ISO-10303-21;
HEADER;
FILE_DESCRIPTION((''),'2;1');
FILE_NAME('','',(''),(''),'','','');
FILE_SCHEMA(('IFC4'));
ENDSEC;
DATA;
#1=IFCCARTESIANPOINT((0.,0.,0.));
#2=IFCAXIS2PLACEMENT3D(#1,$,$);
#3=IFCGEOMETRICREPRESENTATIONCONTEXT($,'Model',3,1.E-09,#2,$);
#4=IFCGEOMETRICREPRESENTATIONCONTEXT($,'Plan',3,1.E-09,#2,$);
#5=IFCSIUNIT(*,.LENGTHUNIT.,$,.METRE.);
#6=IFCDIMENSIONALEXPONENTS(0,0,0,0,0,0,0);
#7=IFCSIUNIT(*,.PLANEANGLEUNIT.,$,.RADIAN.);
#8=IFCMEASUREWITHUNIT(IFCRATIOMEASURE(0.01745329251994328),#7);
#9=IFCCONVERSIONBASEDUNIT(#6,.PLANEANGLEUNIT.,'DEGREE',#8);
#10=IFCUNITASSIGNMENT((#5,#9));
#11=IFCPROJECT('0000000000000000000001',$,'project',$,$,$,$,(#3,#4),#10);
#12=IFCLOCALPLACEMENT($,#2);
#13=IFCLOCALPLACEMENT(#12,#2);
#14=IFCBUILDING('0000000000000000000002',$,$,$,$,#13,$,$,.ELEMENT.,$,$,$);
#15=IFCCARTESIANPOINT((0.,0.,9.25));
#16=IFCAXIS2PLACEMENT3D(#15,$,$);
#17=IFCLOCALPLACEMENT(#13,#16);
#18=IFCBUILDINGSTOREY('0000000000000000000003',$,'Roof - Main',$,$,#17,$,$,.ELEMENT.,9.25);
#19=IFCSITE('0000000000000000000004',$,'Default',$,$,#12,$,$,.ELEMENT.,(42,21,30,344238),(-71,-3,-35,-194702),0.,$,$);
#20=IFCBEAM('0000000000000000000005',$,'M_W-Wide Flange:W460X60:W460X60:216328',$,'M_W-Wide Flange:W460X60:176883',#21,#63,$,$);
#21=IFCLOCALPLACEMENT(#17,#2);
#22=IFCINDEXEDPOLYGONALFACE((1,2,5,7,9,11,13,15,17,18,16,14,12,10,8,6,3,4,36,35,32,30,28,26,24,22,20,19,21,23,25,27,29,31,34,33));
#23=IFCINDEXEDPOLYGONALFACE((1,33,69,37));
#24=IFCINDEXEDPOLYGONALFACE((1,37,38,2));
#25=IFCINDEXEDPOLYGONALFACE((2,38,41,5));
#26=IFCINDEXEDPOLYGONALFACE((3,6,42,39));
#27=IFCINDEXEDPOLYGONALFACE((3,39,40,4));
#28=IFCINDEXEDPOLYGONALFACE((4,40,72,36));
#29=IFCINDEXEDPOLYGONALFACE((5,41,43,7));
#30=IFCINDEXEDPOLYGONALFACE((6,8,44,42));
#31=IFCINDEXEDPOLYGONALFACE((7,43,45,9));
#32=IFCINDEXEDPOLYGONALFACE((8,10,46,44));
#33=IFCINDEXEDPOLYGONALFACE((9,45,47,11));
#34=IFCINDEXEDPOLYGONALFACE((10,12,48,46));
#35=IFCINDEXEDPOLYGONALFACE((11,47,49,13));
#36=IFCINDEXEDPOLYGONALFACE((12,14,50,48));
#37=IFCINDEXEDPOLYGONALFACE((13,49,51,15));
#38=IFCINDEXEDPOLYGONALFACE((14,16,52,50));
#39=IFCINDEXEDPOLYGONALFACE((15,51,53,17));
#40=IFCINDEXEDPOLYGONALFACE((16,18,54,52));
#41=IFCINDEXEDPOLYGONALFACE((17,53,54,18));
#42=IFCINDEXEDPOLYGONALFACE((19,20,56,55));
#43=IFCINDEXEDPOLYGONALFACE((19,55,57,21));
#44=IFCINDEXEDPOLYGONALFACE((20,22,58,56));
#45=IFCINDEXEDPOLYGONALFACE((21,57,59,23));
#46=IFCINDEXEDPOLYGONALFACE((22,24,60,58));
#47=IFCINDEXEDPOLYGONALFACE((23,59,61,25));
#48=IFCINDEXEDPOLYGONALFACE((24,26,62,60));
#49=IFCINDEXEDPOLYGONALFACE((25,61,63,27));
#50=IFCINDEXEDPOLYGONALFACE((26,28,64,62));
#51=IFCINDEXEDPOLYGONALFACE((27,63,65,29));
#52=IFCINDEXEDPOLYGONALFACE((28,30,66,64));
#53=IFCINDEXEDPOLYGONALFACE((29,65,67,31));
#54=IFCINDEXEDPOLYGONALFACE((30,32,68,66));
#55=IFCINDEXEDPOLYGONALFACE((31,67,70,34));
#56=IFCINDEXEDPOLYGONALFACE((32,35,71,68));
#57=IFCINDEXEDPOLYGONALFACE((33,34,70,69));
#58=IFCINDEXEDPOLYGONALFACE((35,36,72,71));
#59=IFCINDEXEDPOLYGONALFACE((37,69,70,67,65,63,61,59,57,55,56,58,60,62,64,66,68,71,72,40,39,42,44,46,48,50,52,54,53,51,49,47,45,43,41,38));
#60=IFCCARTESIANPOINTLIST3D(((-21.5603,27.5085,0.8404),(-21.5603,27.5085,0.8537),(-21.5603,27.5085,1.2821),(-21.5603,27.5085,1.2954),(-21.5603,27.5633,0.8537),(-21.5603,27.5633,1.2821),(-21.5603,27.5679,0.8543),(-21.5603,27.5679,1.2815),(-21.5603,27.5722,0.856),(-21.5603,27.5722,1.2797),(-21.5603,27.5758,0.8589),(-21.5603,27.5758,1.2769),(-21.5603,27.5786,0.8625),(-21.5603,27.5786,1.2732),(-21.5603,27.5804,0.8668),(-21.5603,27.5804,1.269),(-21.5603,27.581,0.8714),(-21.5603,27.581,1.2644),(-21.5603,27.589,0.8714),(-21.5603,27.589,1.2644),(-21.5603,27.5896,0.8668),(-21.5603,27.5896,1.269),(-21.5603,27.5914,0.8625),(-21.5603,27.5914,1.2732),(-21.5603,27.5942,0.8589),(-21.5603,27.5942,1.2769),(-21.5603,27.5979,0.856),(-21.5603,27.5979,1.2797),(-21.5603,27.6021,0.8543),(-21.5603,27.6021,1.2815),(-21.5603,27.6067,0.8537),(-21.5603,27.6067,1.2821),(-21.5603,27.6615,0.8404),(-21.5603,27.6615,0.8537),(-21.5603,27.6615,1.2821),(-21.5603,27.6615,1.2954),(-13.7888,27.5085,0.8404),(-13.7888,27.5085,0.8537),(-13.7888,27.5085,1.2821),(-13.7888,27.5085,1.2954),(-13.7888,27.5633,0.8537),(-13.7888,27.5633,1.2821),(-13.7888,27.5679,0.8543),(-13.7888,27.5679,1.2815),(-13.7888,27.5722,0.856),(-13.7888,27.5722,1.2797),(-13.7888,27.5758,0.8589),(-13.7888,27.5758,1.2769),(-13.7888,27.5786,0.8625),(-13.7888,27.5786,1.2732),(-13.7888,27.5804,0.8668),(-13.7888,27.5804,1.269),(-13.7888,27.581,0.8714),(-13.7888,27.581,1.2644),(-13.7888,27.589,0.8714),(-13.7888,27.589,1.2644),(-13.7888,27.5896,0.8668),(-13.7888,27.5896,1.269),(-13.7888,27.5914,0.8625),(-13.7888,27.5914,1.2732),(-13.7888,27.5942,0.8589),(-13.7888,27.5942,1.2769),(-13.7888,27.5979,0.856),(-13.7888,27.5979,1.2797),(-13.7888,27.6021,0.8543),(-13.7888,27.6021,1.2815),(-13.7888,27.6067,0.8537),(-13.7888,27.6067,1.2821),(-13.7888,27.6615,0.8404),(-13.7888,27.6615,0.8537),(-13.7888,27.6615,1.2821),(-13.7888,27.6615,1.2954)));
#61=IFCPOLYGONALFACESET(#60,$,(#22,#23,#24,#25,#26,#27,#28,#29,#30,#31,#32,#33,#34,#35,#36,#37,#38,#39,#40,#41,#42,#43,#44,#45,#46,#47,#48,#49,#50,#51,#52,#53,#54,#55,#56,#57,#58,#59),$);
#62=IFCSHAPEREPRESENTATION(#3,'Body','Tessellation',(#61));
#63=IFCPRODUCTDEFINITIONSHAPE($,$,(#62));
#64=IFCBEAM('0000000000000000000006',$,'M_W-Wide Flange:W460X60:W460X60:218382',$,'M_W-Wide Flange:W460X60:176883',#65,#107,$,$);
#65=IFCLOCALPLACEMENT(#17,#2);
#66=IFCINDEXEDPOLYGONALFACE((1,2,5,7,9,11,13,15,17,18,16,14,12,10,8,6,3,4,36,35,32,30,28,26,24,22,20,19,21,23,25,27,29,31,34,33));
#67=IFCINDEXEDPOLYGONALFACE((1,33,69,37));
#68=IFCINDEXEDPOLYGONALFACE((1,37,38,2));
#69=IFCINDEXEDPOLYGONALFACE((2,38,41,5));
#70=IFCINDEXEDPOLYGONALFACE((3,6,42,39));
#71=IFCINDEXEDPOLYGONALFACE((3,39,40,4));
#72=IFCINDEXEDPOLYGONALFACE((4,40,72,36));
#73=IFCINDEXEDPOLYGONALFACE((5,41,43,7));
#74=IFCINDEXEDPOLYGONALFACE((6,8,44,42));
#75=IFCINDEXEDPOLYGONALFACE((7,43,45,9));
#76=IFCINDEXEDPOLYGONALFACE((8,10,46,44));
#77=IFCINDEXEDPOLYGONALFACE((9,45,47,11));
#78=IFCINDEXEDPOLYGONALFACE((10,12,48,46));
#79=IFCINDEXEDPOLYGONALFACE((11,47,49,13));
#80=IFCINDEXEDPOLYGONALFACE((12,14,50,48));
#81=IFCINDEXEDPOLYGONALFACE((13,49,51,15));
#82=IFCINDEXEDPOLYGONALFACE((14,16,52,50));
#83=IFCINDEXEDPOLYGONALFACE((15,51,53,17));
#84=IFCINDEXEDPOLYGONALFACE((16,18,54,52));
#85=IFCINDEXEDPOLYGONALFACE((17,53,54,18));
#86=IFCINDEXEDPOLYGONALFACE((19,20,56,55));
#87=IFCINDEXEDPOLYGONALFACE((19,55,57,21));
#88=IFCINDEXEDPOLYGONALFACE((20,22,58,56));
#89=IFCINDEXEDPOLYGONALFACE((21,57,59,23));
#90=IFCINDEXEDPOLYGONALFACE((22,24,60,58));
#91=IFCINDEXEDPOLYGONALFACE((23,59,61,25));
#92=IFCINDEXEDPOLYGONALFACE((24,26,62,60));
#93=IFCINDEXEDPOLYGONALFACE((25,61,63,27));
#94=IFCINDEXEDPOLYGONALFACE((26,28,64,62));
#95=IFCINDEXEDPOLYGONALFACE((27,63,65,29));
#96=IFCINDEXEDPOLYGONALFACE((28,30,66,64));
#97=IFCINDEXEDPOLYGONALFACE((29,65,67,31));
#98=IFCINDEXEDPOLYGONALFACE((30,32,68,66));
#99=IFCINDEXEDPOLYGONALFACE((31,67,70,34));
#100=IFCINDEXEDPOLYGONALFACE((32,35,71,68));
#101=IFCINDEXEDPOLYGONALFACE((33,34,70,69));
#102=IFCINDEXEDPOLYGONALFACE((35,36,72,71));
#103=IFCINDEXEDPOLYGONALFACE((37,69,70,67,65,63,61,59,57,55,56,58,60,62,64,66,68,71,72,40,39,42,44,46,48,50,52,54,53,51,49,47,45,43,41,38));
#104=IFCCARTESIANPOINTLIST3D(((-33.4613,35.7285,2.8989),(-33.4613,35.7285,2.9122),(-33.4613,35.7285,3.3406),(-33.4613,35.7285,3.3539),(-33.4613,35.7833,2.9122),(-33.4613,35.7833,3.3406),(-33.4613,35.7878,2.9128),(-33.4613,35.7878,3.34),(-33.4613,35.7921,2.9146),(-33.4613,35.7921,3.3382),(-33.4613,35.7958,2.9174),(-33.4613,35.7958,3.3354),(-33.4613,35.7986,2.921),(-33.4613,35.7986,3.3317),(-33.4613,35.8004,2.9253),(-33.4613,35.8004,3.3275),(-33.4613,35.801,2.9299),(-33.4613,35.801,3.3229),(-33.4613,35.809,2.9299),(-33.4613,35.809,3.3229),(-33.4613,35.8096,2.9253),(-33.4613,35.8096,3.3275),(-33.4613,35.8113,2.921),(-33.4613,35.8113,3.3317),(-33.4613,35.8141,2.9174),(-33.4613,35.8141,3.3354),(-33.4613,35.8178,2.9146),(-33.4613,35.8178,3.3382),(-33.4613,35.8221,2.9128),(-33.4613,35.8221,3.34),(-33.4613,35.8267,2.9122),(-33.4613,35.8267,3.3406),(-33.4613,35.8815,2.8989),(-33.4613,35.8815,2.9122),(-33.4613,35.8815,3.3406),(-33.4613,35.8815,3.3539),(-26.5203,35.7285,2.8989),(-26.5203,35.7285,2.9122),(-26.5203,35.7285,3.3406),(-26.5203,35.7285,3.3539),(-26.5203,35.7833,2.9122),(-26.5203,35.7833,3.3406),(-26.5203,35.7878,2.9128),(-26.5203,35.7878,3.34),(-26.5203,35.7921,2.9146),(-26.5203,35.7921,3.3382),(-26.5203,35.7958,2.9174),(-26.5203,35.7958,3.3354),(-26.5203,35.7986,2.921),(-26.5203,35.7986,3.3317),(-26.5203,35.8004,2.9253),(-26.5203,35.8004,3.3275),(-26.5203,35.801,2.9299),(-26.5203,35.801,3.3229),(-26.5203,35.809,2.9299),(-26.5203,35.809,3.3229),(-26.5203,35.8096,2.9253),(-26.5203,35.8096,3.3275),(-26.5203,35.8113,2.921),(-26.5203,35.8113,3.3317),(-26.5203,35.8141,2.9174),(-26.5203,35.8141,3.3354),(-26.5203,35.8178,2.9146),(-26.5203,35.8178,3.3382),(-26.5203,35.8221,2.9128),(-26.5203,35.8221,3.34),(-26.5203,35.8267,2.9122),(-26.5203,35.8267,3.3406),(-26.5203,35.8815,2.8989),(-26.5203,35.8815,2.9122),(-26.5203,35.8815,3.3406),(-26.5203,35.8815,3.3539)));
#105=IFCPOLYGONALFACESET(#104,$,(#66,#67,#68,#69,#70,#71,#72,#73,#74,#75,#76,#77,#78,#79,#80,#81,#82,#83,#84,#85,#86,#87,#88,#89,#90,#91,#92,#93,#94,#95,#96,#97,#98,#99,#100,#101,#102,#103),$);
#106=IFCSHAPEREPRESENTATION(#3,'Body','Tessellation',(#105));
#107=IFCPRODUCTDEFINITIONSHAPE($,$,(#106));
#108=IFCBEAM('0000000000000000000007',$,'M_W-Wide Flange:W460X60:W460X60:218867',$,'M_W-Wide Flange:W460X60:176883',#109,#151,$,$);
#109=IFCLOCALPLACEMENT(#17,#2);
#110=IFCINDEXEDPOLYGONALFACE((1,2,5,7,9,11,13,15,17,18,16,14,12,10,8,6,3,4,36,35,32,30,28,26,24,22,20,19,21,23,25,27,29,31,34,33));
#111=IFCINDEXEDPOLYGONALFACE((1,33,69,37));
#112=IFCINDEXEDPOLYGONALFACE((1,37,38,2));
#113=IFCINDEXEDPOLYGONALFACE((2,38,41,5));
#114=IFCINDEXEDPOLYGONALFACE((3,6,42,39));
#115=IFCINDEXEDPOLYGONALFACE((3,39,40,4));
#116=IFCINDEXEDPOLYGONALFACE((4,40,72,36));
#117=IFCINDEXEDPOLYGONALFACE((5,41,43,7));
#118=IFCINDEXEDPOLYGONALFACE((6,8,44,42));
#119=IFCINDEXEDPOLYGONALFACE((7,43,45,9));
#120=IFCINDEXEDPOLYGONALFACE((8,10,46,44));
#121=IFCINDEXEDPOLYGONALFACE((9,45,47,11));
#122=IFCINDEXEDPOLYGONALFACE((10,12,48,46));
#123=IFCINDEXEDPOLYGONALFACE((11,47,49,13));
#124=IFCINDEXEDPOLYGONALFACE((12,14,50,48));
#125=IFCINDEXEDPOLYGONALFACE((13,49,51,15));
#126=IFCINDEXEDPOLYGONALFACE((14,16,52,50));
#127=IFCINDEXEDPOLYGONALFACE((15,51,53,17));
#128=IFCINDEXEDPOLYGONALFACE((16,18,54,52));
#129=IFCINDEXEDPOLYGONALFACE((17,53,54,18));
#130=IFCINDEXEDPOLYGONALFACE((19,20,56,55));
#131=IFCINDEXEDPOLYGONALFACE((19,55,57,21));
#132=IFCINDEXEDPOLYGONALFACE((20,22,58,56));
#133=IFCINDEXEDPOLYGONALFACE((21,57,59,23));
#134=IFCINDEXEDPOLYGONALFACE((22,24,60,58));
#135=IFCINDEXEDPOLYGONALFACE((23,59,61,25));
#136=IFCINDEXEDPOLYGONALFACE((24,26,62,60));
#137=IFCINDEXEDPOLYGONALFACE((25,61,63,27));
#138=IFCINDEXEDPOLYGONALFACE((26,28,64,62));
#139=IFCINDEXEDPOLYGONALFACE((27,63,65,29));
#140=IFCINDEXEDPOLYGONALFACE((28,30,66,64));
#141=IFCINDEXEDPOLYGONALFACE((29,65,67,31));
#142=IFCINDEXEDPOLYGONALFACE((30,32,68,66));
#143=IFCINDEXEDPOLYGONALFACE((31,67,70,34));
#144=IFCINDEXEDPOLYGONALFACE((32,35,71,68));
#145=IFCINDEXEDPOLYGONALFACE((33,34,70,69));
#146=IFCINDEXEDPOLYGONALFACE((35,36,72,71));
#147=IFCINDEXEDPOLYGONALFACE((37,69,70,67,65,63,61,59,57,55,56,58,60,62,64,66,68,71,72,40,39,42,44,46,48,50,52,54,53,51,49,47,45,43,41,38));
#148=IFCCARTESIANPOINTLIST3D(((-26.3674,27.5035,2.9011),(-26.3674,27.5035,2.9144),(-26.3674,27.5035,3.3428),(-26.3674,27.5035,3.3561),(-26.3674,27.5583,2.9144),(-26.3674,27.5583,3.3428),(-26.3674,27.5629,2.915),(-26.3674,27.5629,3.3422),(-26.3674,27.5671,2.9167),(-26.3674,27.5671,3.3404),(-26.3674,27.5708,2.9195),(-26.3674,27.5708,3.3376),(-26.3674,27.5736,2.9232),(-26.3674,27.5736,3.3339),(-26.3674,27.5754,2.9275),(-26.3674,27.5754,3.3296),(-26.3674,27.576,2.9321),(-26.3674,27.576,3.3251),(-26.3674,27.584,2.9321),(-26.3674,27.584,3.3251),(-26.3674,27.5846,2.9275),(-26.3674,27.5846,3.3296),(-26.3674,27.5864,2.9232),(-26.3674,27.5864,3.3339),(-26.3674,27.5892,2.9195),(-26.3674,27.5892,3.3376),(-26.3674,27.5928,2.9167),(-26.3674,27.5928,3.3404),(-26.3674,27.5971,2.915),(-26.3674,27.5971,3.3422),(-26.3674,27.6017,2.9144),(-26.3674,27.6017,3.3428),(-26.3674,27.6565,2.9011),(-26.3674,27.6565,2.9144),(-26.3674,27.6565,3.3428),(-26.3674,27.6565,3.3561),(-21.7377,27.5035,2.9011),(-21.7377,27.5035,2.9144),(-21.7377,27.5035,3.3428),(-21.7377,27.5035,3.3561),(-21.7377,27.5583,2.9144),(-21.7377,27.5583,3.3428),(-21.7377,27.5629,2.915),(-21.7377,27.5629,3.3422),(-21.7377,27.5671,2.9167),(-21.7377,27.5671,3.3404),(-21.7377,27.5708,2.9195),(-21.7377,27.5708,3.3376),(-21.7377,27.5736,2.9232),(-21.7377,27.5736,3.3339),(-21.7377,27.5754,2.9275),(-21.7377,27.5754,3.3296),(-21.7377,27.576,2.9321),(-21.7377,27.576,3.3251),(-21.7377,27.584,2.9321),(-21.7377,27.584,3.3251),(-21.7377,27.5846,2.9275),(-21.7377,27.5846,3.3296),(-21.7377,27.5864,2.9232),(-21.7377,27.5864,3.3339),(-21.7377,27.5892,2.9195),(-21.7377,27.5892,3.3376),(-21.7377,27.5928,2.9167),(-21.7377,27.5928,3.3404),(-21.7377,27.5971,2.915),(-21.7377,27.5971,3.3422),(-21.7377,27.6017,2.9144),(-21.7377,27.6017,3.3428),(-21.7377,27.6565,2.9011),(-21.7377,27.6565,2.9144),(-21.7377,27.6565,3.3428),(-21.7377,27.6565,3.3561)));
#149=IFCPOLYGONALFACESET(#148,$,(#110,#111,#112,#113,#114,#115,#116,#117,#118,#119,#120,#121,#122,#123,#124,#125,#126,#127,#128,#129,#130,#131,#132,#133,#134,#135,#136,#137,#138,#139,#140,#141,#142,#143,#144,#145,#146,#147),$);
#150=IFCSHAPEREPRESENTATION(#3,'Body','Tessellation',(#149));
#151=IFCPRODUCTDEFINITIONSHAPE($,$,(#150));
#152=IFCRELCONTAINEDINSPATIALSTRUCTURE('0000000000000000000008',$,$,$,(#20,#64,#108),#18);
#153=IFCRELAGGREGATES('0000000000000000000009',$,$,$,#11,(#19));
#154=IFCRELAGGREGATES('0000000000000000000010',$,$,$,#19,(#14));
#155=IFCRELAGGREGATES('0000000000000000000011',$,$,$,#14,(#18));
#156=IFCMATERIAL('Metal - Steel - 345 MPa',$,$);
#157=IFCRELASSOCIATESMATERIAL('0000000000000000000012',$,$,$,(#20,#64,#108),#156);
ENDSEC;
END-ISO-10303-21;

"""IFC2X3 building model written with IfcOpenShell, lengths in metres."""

from ifc_helpers import new_model, entity, si_unit, converted_unit, frame, frame_2d, origin, place, context, project, spatial, polyline, circle_curve, parameter, trimmed, segment, composite_curve, outline, extrude, material, element, save


model = new_model("IFC2X3")

# Units and contexts
model_context = context("Model", 3, precision=1e-09, world=origin())
plan_context = context("Plan", 3, precision=1e-09, world=origin())
ifc_project = project(units=[si_unit("LENGTHUNIT", "METRE"), converted_unit("PLANEANGLEUNIT", "DEGREE", entity("IfcRatioMeasure", 0.01745329251994328), si_unit("PLANEANGLEUNIT", "RADIAN"), dimensions=[0, 0, 0, 0, 0, 0, 0])], contexts=[model_context, plan_context])

# Site, building, storey
site_placement = place(None, origin())
site = spatial("IfcSite", under=ifc_project, at=site_placement, Name="Default", CompositionType="ELEMENT", RefLatitude=(42, 21, 30, 344238), RefLongitude=(-71, -3, -35, -194702), RefElevation=0.0)
building_placement = place(site_placement, origin())
building = spatial("IfcBuilding", under=site, at=building_placement, CompositionType="ELEMENT")
storey_placement = place(building_placement, frame((0.0, 0.0, 9.25)))
storey = spatial("IfcBuildingStorey", under=building, at=storey_placement, Name="Roof - Main", CompositionType="ELEMENT", Elevation=9.25)

# Shared definitions
ifc_material_1 = material(Name="Metal - Steel - 345 MPa")

# Beams
beam_1_placement = place(storey_placement, frame((-7.2776, 27.585, 1.2954), z_axis=(0.0, 0.0, 1.0), x_axis=(0.0, -1.0, 0.0)))
element("IfcBeam", 1, at=beam_1_placement, inside=storey, material=ifc_material_1, Name="M_W-Wide Flange:W460X60:W460X60:216328", ObjectType="M_W-Wide Flange:W460X60:176883", context=model_context, shape_type="SweptSolid", body=[
    extrude(outline(composite_curve([segment(polyline([(0.2142, -0.0765), (0.2275, -0.0765)]), True, "CONTINUOUS"), segment(polyline([(0.2275, -0.0765), (0.2275, 0.0765)]), True, "CONTINUOUS"), segment(polyline([(0.2275, 0.0765), (0.2142, 0.0765)]), True, "CONTINUOUS"), segment(polyline([(0.2142, 0.0765), (0.2142, 0.0217)]), True, "CONTINUOUS"), segment(trimmed(circle_curve(frame_2d((0.1965, 0.0217), x_axis=(0.0, 1.0)), 0.0177), [parameter(180.0)], [parameter(270.0)], True, "PARAMETER"), False, "CONTINUOUS"), segment(polyline([(0.1965, 0.004), (-0.1965, 0.004)]), True, "CONTINUOUS"), segment(trimmed(circle_curve(frame_2d((-0.1965, 0.0217), x_axis=(0.0, 1.0)), 0.0177), [parameter(90.0)], [parameter(180.0)], True, "PARAMETER"), False, "CONTINUOUS"), segment(polyline([(-0.2142, 0.0217), (-0.2142, 0.0765)]), True, "CONTINUOUS"), segment(polyline([(-0.2142, 0.0765), (-0.2275, 0.0765)]), True, "CONTINUOUS"), segment(polyline([(-0.2275, 0.0765), (-0.2275, -0.0765)]), True, "CONTINUOUS"), segment(polyline([(-0.2275, -0.0765), (-0.2142, -0.0765)]), True, "CONTINUOUS"), segment(polyline([(-0.2142, -0.0765), (-0.2142, -0.0217)]), True, "CONTINUOUS"), segment(trimmed(circle_curve(frame_2d((-0.1965, -0.0217), x_axis=(0.0, 1.0)), 0.0177), [parameter(360.0)], [parameter(90.0)], True, "PARAMETER"), False, "CONTINUOUS"), segment(polyline([(-0.1965, -0.004), (0.1965, -0.004)]), True, "CONTINUOUS"), segment(trimmed(circle_curve(frame_2d((0.1965, -0.0217), x_axis=(0.0, 1.0)), 0.0177), [parameter(270.0)], [parameter(0.0)], True, "PARAMETER"), False, "CONTINUOUS"), segment(polyline([(0.2142, -0.0217), (0.2142, -0.0765)]), True, "CONTINUOUS")], self_intersect=False)), frame((0.0, -14.2827, -0.2275), z_axis=(0.0, 1.0, 0.0), x_axis=(0.0, 0.0, -1.0)), (0.0, 0.0, 1.0), 7.7715),
])
beam_2_placement = place(storey_placement, frame((-6.691, 35.805, 3.3539), z_axis=(0.0, 0.0, 1.0), x_axis=(0.0, -1.0, 0.0)))
element("IfcBeam", 2, at=beam_2_placement, inside=storey, material=ifc_material_1, Name="M_W-Wide Flange:W460X60:W460X60:218382", ObjectType="M_W-Wide Flange:W460X60:176883", context=model_context, shape_type="SweptSolid", body=[
    extrude(outline(composite_curve([segment(polyline([(-0.0765, -0.2142), (-0.0765, -0.2275)]), True, "CONTINUOUS"), segment(polyline([(-0.0765, -0.2275), (0.0765, -0.2275)]), True, "CONTINUOUS"), segment(polyline([(0.0765, -0.2275), (0.0765, -0.2142)]), True, "CONTINUOUS"), segment(polyline([(0.0765, -0.2142), (0.0217, -0.2142)]), True, "CONTINUOUS"), segment(trimmed(circle_curve(frame_2d((0.0217, -0.1965), x_axis=(1.0, 0.0)), 0.0177), [parameter(180.0)], [parameter(270.0)], True, "PARAMETER"), False, "CONTINUOUS"), segment(polyline([(0.004, -0.1965), (0.004, 0.1965)]), True, "CONTINUOUS"), segment(trimmed(circle_curve(frame_2d((0.0217, 0.1965), x_axis=(1.0, 0.0)), 0.0177), [parameter(90.0)], [parameter(180.0)], True, "PARAMETER"), False, "CONTINUOUS"), segment(polyline([(0.0217, 0.2142), (0.0765, 0.2142)]), True, "CONTINUOUS"), segment(polyline([(0.0765, 0.2142), (0.0765, 0.2275)]), True, "CONTINUOUS"), segment(polyline([(0.0765, 0.2275), (-0.0765, 0.2275)]), True, "CONTINUOUS"), segment(polyline([(-0.0765, 0.2275), (-0.0765, 0.2142)]), True, "CONTINUOUS"), segment(polyline([(-0.0765, 0.2142), (-0.0217, 0.2142)]), True, "CONTINUOUS"), segment(trimmed(circle_curve(frame_2d((-0.0217, 0.1965), x_axis=(1.0, 0.0)), 0.0177), [parameter(360.0)], [parameter(90.0)], True, "PARAMETER"), False, "CONTINUOUS"), segment(polyline([(-0.004, 0.1965), (-0.004, -0.1965)]), True, "CONTINUOUS"), segment(trimmed(circle_curve(frame_2d((-0.0217, -0.1965), x_axis=(1.0, 0.0)), 0.0177), [parameter(270.0)], [parameter(0.0)], True, "PARAMETER"), False, "CONTINUOUS"), segment(polyline([(-0.0217, -0.2142), (-0.0765, -0.2142)]), True, "CONTINUOUS")], self_intersect=False)), frame((0.0, -26.7703, -0.2275), z_axis=(0.0, -1.0, 0.0), x_axis=(1.0, 0.0, 0.0)), (0.0, 0.0, -1.0), 6.941),
])
beam_3_placement = place(storey_placement, frame((-6.691, 27.58, 3.3561), z_axis=(0.0, 0.0, 1.0), x_axis=(0.0, -1.0, 0.0)))
element("IfcBeam", 3, at=beam_3_placement, inside=storey, material=ifc_material_1, Name="M_W-Wide Flange:W460X60:W460X60:218867", ObjectType="M_W-Wide Flange:W460X60:176883", context=model_context, shape_type="SweptSolid", body=[
    extrude(outline(composite_curve([segment(polyline([(0.2142, -0.0765), (0.2275, -0.0765)]), True, "CONTINUOUS"), segment(polyline([(0.2275, -0.0765), (0.2275, 0.0765)]), True, "CONTINUOUS"), segment(polyline([(0.2275, 0.0765), (0.2142, 0.0765)]), True, "CONTINUOUS"), segment(polyline([(0.2142, 0.0765), (0.2142, 0.0217)]), True, "CONTINUOUS"), segment(trimmed(circle_curve(frame_2d((0.1965, 0.0217), x_axis=(0.0, 1.0)), 0.0177), [parameter(180.0)], [parameter(270.0)], True, "PARAMETER"), False, "CONTINUOUS"), segment(polyline([(0.1965, 0.004), (-0.1965, 0.004)]), True, "CONTINUOUS"), segment(trimmed(circle_curve(frame_2d((-0.1965, 0.0217), x_axis=(0.0, 1.0)), 0.0177), [parameter(90.0)], [parameter(180.0)], True, "PARAMETER"), False, "CONTINUOUS"), segment(polyline([(-0.2142, 0.0217), (-0.2142, 0.0765)]), True, "CONTINUOUS"), segment(polyline([(-0.2142, 0.0765), (-0.2275, 0.0765)]), True, "CONTINUOUS"), segment(polyline([(-0.2275, 0.0765), (-0.2275, -0.0765)]), True, "CONTINUOUS"), segment(polyline([(-0.2275, -0.0765), (-0.2142, -0.0765)]), True, "CONTINUOUS"), segment(polyline([(-0.2142, -0.0765), (-0.2142, -0.0217)]), True, "CONTINUOUS"), segment(trimmed(circle_curve(frame_2d((-0.1965, -0.0217), x_axis=(0.0, 1.0)), 0.0177), [parameter(360.0)], [parameter(90.0)], True, "PARAMETER"), False, "CONTINUOUS"), segment(polyline([(-0.1965, -0.004), (0.1965, -0.004)]), True, "CONTINUOUS"), segment(trimmed(circle_curve(frame_2d((0.1965, -0.0217), x_axis=(0.0, 1.0)), 0.0177), [parameter(270.0)], [parameter(0.0)], True, "PARAMETER"), False, "CONTINUOUS"), segment(polyline([(0.2142, -0.0217), (0.2142, -0.0765)]), True, "CONTINUOUS")], self_intersect=False)), frame((0.0, -19.6764, -0.2275), z_axis=(0.0, 1.0, 0.0), x_axis=(0.0, 0.0, -1.0)), (0.0, 0.0, 1.0), 4.6297),
])

save(model, "model.ifc")
